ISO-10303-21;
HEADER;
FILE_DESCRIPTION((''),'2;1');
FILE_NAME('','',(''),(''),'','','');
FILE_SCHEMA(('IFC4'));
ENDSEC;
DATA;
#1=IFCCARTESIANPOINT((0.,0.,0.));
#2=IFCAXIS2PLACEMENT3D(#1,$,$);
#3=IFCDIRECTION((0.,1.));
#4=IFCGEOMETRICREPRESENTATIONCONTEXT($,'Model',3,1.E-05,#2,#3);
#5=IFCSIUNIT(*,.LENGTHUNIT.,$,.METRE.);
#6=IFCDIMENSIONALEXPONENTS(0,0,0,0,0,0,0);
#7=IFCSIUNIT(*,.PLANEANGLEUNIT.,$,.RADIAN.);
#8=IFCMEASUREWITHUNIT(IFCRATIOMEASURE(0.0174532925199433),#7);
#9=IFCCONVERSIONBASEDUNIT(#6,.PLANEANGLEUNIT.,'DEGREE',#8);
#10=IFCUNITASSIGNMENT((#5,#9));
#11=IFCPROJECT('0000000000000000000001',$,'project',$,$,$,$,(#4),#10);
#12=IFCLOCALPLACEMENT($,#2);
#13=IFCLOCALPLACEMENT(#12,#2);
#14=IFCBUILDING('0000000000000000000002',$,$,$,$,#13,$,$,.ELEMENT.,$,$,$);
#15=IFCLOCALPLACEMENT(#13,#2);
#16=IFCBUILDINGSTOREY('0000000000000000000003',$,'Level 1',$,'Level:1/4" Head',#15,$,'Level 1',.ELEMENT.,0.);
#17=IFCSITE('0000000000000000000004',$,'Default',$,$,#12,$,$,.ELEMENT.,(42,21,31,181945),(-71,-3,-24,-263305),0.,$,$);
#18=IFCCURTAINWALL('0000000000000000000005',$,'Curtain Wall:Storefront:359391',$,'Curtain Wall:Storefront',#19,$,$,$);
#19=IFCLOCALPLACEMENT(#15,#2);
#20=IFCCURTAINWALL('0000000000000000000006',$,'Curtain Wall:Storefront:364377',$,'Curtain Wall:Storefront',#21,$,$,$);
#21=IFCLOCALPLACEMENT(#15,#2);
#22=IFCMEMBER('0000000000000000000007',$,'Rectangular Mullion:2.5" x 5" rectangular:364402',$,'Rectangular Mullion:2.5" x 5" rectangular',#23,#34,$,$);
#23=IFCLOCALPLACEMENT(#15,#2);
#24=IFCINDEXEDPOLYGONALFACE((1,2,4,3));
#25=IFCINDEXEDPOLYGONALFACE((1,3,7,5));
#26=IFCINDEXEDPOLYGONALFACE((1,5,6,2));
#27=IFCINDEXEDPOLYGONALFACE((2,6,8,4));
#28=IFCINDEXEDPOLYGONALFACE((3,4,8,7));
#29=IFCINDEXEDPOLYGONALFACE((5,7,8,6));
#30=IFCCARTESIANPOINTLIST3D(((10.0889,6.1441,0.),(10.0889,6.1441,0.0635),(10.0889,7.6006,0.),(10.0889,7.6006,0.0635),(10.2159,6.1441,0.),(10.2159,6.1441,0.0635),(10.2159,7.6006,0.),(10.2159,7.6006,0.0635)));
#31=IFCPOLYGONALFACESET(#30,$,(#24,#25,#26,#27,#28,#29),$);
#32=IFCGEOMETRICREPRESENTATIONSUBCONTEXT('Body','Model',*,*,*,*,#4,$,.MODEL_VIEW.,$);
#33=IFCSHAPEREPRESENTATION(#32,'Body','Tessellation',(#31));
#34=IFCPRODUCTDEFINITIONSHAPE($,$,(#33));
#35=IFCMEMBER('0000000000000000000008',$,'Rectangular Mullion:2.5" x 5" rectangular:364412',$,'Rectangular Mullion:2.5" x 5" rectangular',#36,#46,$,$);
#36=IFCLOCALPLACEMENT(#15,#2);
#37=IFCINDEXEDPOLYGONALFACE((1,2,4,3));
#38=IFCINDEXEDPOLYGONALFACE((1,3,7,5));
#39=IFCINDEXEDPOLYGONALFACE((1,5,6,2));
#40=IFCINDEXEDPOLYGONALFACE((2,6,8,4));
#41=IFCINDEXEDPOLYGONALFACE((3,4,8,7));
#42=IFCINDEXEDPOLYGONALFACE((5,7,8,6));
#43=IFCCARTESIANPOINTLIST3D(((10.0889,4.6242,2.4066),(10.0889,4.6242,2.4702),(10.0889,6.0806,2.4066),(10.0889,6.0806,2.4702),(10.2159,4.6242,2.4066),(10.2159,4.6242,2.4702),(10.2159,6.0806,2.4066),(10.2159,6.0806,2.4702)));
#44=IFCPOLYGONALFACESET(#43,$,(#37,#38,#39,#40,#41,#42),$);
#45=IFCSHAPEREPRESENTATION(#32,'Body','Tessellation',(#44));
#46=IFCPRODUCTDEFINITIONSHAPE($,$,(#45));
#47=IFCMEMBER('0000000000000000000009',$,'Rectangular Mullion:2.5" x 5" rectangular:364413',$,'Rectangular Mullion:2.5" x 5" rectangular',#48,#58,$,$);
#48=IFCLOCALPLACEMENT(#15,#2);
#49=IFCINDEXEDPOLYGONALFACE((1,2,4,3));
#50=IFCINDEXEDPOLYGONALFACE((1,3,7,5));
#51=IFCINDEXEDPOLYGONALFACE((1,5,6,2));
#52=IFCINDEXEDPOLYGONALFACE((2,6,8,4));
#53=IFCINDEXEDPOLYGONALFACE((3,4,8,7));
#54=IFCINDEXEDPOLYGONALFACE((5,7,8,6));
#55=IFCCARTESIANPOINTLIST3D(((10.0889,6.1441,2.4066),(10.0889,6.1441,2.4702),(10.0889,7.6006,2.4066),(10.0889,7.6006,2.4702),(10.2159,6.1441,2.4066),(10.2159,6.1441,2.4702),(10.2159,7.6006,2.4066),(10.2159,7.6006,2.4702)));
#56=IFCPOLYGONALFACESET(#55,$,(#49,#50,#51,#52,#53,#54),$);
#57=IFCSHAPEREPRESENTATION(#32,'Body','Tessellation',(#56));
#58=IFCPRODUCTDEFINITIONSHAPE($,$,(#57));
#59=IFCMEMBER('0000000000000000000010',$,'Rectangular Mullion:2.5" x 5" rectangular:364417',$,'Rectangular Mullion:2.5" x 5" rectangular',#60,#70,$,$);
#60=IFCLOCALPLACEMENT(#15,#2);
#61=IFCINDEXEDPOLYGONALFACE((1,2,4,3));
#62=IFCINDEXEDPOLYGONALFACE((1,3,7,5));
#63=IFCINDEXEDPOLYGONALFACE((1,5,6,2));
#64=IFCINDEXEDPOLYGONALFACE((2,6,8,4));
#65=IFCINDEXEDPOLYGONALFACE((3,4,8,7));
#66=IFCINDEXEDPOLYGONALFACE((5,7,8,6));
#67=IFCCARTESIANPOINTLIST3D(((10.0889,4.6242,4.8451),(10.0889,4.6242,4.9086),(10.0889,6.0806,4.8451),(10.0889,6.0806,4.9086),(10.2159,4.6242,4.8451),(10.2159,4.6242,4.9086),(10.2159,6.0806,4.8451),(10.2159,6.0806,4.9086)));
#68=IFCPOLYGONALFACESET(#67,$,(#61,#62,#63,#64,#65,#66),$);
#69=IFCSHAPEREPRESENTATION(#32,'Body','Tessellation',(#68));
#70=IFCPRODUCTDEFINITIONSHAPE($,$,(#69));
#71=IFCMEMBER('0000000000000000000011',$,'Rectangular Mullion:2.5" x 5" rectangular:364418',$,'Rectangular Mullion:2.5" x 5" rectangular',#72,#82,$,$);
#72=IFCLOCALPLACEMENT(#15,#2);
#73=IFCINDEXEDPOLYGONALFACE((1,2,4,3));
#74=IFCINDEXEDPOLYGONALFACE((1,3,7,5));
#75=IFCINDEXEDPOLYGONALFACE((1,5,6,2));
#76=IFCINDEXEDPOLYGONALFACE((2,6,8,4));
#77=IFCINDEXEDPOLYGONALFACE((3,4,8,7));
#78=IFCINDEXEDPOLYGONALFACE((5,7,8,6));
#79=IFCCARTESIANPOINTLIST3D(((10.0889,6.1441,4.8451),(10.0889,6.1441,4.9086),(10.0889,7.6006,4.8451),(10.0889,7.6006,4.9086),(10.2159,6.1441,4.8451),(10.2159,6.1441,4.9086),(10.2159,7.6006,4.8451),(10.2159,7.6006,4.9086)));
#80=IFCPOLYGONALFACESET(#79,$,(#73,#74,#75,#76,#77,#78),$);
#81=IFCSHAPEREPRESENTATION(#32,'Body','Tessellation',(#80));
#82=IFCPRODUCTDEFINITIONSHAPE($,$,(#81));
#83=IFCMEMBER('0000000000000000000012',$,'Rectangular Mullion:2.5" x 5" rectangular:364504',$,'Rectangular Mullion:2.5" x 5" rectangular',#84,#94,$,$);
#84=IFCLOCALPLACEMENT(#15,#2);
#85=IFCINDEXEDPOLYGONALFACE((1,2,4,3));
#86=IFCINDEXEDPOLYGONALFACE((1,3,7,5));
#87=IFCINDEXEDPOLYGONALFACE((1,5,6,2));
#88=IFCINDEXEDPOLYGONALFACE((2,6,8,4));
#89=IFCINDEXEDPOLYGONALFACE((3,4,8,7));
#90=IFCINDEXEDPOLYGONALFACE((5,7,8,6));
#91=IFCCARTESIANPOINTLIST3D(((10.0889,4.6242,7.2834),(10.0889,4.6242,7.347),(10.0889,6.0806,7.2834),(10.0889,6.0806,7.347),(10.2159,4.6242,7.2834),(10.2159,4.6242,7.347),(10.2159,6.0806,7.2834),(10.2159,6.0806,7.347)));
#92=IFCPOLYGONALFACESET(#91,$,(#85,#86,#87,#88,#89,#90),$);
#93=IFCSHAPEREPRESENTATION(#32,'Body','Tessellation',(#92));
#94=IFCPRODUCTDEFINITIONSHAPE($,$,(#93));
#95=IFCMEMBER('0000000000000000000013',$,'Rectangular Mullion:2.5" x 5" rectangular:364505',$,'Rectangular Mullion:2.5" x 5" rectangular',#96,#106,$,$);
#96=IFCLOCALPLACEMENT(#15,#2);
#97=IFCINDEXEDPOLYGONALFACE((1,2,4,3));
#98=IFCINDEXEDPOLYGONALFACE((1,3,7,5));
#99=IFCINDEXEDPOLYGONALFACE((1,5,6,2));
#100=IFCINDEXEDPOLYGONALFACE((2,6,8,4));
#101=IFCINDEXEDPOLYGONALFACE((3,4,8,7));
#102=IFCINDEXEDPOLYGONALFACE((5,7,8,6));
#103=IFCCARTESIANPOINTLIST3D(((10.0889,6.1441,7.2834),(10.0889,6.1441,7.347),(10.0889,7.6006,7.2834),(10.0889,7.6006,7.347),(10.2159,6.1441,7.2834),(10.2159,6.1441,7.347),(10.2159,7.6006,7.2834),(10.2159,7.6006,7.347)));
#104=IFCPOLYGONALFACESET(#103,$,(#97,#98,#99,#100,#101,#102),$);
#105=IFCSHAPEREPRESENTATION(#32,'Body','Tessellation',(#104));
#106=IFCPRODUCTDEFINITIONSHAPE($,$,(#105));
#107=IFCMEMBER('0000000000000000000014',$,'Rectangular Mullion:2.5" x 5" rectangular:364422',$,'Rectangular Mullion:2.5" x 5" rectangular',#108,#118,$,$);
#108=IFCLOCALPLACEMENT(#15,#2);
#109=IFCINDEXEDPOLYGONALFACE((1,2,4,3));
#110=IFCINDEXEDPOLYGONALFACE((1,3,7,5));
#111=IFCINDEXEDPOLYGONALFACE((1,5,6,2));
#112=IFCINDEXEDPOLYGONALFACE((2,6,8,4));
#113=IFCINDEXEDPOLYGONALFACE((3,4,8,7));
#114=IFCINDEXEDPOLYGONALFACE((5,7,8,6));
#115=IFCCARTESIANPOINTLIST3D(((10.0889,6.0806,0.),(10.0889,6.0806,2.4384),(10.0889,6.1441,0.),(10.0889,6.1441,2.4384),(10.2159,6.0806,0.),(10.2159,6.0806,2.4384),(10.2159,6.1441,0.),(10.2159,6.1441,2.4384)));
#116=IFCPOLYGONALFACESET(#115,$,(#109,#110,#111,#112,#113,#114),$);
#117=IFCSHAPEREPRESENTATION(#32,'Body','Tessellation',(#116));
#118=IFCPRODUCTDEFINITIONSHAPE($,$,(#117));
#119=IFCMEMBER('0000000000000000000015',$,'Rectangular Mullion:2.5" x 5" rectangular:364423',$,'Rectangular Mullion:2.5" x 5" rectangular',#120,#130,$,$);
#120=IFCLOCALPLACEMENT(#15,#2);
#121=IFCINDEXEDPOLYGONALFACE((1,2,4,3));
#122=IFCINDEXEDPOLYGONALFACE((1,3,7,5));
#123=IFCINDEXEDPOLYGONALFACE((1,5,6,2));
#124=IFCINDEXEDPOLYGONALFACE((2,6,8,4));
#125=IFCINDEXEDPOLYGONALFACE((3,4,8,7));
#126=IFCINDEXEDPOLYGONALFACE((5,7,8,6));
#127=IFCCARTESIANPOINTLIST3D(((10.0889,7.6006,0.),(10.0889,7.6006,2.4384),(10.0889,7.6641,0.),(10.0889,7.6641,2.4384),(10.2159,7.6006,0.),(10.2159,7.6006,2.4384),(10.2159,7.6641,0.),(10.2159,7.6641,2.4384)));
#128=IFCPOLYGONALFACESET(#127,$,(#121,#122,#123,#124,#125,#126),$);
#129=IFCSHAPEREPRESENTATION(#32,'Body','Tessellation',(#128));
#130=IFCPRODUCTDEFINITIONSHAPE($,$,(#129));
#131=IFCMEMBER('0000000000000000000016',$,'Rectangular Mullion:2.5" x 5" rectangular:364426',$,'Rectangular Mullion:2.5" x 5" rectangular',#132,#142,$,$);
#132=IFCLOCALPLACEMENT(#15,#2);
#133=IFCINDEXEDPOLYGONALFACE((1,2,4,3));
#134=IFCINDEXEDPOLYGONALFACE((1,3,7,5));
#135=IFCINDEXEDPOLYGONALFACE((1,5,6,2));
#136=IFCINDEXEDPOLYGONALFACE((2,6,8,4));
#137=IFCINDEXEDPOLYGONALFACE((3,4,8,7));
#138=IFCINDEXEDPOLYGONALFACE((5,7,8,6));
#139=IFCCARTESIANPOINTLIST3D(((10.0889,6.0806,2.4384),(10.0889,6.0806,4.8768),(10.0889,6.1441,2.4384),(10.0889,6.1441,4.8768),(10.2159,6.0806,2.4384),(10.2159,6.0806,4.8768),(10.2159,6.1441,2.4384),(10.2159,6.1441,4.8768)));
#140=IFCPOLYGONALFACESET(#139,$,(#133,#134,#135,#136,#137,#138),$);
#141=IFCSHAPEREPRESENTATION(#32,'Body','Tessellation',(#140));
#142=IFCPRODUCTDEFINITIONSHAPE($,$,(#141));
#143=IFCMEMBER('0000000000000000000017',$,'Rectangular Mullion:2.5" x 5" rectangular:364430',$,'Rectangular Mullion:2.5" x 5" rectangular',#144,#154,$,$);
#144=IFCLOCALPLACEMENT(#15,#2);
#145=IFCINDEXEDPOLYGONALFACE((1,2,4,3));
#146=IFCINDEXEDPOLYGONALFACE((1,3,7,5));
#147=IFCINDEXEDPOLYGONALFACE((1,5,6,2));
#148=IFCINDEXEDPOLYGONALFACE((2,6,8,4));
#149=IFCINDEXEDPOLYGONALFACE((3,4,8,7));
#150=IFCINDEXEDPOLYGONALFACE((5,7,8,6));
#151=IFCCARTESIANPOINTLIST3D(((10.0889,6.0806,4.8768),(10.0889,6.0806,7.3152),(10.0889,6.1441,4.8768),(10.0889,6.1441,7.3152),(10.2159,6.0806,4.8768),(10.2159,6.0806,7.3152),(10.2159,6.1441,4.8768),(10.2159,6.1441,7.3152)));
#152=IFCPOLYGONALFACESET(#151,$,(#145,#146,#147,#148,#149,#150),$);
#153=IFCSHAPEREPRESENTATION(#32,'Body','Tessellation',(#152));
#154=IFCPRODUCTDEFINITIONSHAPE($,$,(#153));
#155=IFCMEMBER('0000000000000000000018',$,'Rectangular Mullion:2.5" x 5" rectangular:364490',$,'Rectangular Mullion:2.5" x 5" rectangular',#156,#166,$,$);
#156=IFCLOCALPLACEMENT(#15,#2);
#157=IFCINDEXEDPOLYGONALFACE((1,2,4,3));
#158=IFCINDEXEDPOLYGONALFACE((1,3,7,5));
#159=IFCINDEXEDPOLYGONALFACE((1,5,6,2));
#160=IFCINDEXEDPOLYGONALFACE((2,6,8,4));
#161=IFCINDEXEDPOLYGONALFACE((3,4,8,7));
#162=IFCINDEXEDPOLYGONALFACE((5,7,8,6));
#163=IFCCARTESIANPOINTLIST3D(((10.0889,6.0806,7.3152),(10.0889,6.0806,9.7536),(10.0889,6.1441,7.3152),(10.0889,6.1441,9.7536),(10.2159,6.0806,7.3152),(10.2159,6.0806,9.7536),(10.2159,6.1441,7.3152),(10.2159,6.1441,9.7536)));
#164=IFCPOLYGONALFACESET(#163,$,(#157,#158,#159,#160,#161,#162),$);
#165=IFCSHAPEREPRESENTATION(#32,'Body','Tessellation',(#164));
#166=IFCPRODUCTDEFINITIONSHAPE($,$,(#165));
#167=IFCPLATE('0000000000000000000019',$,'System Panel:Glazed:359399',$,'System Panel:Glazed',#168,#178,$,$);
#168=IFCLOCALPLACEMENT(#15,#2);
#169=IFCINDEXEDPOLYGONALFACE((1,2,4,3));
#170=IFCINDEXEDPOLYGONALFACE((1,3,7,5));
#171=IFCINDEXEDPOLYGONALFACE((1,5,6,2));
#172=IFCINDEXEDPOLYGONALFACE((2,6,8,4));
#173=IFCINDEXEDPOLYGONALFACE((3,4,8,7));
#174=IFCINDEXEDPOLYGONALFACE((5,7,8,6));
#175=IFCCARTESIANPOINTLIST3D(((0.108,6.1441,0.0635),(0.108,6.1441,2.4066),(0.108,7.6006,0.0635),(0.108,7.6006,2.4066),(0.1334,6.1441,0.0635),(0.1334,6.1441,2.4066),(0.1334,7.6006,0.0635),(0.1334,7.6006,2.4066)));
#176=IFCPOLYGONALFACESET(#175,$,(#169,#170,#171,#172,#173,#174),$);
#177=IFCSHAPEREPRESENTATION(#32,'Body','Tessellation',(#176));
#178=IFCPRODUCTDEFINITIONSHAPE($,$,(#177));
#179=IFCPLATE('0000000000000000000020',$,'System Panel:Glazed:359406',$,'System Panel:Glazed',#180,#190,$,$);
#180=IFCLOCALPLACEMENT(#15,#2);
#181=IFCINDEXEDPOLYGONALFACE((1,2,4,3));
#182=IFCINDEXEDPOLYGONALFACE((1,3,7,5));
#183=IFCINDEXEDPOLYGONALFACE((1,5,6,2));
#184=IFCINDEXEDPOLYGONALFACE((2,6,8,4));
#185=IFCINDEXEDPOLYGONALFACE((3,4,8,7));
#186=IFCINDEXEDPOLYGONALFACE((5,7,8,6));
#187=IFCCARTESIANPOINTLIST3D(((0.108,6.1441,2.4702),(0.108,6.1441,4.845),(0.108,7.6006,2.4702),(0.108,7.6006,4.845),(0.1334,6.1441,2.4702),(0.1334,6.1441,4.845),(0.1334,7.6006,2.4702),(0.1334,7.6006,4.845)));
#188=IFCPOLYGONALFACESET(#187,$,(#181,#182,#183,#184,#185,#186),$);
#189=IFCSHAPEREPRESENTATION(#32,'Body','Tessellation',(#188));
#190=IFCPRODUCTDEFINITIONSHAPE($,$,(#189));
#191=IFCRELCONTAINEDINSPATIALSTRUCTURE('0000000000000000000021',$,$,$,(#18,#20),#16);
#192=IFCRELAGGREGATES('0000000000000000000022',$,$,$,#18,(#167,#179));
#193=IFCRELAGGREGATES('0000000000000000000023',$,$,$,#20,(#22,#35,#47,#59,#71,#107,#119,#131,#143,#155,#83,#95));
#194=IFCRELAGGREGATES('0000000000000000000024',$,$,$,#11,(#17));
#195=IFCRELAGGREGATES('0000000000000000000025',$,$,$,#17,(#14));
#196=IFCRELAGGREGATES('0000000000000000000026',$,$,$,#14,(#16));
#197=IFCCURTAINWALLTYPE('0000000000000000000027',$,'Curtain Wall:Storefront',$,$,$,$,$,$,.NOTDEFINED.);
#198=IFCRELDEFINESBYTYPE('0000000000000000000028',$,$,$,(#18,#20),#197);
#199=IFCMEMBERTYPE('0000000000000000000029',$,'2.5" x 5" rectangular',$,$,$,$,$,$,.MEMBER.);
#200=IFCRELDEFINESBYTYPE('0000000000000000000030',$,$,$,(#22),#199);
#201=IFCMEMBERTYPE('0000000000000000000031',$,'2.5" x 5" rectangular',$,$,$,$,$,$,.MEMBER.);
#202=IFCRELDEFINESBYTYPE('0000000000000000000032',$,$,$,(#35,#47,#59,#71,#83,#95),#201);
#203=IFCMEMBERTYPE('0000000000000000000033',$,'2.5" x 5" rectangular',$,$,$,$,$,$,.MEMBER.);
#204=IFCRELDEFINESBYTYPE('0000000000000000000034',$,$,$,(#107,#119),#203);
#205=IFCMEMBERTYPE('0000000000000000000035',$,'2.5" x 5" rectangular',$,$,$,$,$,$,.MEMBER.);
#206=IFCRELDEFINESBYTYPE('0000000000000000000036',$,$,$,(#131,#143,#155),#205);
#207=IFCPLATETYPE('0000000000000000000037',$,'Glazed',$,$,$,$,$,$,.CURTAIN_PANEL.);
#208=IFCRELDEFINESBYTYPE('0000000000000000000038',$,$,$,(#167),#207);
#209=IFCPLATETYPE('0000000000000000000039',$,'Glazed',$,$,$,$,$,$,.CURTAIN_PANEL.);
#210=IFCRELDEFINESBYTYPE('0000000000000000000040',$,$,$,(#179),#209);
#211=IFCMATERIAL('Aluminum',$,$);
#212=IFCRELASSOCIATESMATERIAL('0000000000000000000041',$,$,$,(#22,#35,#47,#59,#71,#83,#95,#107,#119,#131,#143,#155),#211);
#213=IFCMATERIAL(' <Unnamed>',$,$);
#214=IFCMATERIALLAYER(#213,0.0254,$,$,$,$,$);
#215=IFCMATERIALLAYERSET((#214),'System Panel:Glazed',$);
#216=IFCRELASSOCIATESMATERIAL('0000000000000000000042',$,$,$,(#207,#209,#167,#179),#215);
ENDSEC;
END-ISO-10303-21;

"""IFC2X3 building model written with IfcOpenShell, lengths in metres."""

from ifc_helpers import new_model, entity, si_unit, converted_unit, direction, frame, frame_2d, origin, origin_2d_with_axis, place, context, subcontext, project, spatial, rectangle, extrude, source, transform, mapped, material, layer, layer_set, layer_usage, type_object, type_shapes, element, aggregate, save


model = new_model("IFC2X3")

# Units and contexts
model_context = context("Model", 3, precision=1e-05, world=origin(), true_north=direction((0.0, 1.0)))
body_context = subcontext(model_context, "Body", "Model", "MODEL_VIEW")
ifc_project = project(units=[si_unit("LENGTHUNIT", "METRE"), converted_unit("PLANEANGLEUNIT", "DEGREE", entity("IfcRatioMeasure", 0.0174532925199433), si_unit("PLANEANGLEUNIT", "RADIAN"), dimensions=[0, 0, 0, 0, 0, 0, 0])], contexts=[model_context])

# Site, building, storey
site_placement = place(None, origin())
site = spatial("IfcSite", under=ifc_project, at=site_placement, Name="Default", CompositionType="ELEMENT", RefLatitude=(42, 21, 31, 181945), RefLongitude=(-71, -3, -24, -263305), RefElevation=0.0)
building_placement = place(site_placement, origin())
building = spatial("IfcBuilding", under=site, at=building_placement, CompositionType="ELEMENT")
storey_placement = place(building_placement, origin())
storey = spatial("IfcBuildingStorey", under=building, at=storey_placement, Name="Level 1", ObjectType="Level:1/4\" Head", LongName="Level 1", CompositionType="ELEMENT", Elevation=0.0)

# Curtain walls, members
curtain_wall_type = type_object("IfcCurtainWallType", Name="Curtain Wall:Storefront", PredefinedType="NOTDEFINED")
curtain_wall_1_placement = place(storey_placement, origin())
curtain_wall_1 = element("IfcCurtainWall", 1, at=curtain_wall_1_placement, inside=storey, type_object=curtain_wall_type, Name="Curtain Wall:Storefront:359391", ObjectType="Curtain Wall:Storefront")
ifc_material_1 = material(Name="Aluminum")
curtain_wall_2_placement = place(storey_placement, origin())
curtain_wall_2 = element("IfcCurtainWall", 2, at=curtain_wall_2_placement, inside=storey, type_object=curtain_wall_type, Name="Curtain Wall:Storefront:364377", ObjectType="Curtain Wall:Storefront")
member_type_1 = type_object("IfcMemberType", Name="2.5\" x 5\" rectangular", PredefinedType="MEMBER")
shared_shape_1 = source(origin(), body_context, "Body", "SweptSolid", [
    extrude(rectangle(XDim=0.127, YDim=0.0635, at=origin_2d_with_axis()), frame((-0.0318, 0.0, -1.4565), z_axis=(0.0, 0.0, 1.0), x_axis=(0.0, -1.0, 0.0)), (0.0, 0.0, 1.0), 1.4565),
])
type_shapes(member_type_1, [shared_shape_1])
member_1_placement = place(storey_placement, frame((10.1524, 6.1441, 0.0), z_axis=(0.0, -1.0, 0.0), x_axis=(0.0, 0.0, -1.0)))
member_1 = element("IfcMember", 3, at=member_1_placement, type_object=member_type_1, material=ifc_material_1, Name="Rectangular Mullion:2.5\" x 5\" rectangular:364402", ObjectType="Rectangular Mullion:2.5\" x 5\" rectangular", context=body_context, shape_type="MappedRepresentation", body=[
    mapped(shared_shape_1, transform((0.0, 0.0, 0.0), scale=1.0)),
])
member_type_2 = type_object("IfcMemberType", Name="2.5\" x 5\" rectangular", PredefinedType="MEMBER")
shared_shape_2 = source(origin(), body_context, "Body", "SweptSolid", [
    extrude(rectangle(XDim=0.127, YDim=0.0635, at=origin_2d_with_axis()), frame((0.0, 0.0, -1.4565), z_axis=(0.0, 0.0, 1.0), x_axis=(0.0, -1.0, 0.0)), (0.0, 0.0, 1.0), 1.4565),
])
type_shapes(member_type_2, [shared_shape_2])
member_2_placement = place(storey_placement, frame((10.1524, 6.0806, 2.4384), z_axis=(0.0, 1.0, 0.0), x_axis=(0.0, 0.0, 1.0)))
member_2 = element("IfcMember", 4, at=member_2_placement, type_object=member_type_2, material=ifc_material_1, Name="Rectangular Mullion:2.5\" x 5\" rectangular:364412", ObjectType="Rectangular Mullion:2.5\" x 5\" rectangular", context=body_context, shape_type="MappedRepresentation", body=[
    mapped(shared_shape_2, transform((0.0, 0.0, 0.0), scale=1.0)),
])
member_3_placement = place(storey_placement, frame((10.1524, 7.6006, 2.4384), z_axis=(0.0, 1.0, 0.0), x_axis=(0.0, 0.0, 1.0)))
member_3 = element("IfcMember", 5, at=member_3_placement, type_object=member_type_2, material=ifc_material_1, Name="Rectangular Mullion:2.5\" x 5\" rectangular:364413", ObjectType="Rectangular Mullion:2.5\" x 5\" rectangular", context=body_context, shape_type="MappedRepresentation", body=[
    mapped(shared_shape_2, transform((0.0, 0.0, 0.0), scale=1.0)),
])
member_4_placement = place(storey_placement, frame((10.1524, 6.0806, 4.8768), z_axis=(0.0, 1.0, 0.0), x_axis=(0.0, 0.0, 1.0)))
member_4 = element("IfcMember", 6, at=member_4_placement, type_object=member_type_2, material=ifc_material_1, Name="Rectangular Mullion:2.5\" x 5\" rectangular:364417", ObjectType="Rectangular Mullion:2.5\" x 5\" rectangular", context=body_context, shape_type="MappedRepresentation", body=[
    mapped(shared_shape_2, transform((0.0, 0.0, 0.0), scale=1.0)),
])
member_5_placement = place(storey_placement, frame((10.1524, 7.6006, 4.8768), z_axis=(0.0, 1.0, 0.0), x_axis=(0.0, 0.0, 1.0)))
member_5 = element("IfcMember", 7, at=member_5_placement, type_object=member_type_2, material=ifc_material_1, Name="Rectangular Mullion:2.5\" x 5\" rectangular:364418", ObjectType="Rectangular Mullion:2.5\" x 5\" rectangular", context=body_context, shape_type="MappedRepresentation", body=[
    mapped(shared_shape_2, transform((0.0, 0.0, 0.0), scale=1.0)),
])
member_6_placement = place(storey_placement, frame((10.1524, 6.0806, 7.3152), z_axis=(0.0, 1.0, 0.0), x_axis=(0.0, 0.0, 1.0)))
member_6 = element("IfcMember", 8, at=member_6_placement, type_object=member_type_2, material=ifc_material_1, Name="Rectangular Mullion:2.5\" x 5\" rectangular:364504", ObjectType="Rectangular Mullion:2.5\" x 5\" rectangular", context=body_context, shape_type="MappedRepresentation", body=[
    mapped(shared_shape_2, transform((0.0, 0.0, 0.0), scale=1.0)),
])
member_7_placement = place(storey_placement, frame((10.1524, 7.6006, 7.3152), z_axis=(0.0, 1.0, 0.0), x_axis=(0.0, 0.0, 1.0)))
member_7 = element("IfcMember", 9, at=member_7_placement, type_object=member_type_2, material=ifc_material_1, Name="Rectangular Mullion:2.5\" x 5\" rectangular:364505", ObjectType="Rectangular Mullion:2.5\" x 5\" rectangular", context=body_context, shape_type="MappedRepresentation", body=[
    mapped(shared_shape_2, transform((0.0, 0.0, 0.0), scale=1.0)),
])
member_type_3 = type_object("IfcMemberType", Name="2.5\" x 5\" rectangular", PredefinedType="MEMBER")
shared_shape_3 = source(origin(), body_context, "Body", "SweptSolid", [
    extrude(rectangle(XDim=0.127, YDim=0.0635, at=origin_2d_with_axis()), frame((0.0, 0.0, -2.4384), z_axis=(0.0, 0.0, 1.0), x_axis=(0.0, -1.0, 0.0)), (0.0, 0.0, 1.0), 2.4384),
])
type_shapes(member_type_3, [shared_shape_3])
member_8_placement = place(storey_placement, frame((10.1524, 6.1124, 0.0), z_axis=(0.0, 0.0, -1.0), x_axis=(0.0, 1.0, 0.0)))
member_8 = element("IfcMember", 10, at=member_8_placement, type_object=member_type_3, material=ifc_material_1, Name="Rectangular Mullion:2.5\" x 5\" rectangular:364422", ObjectType="Rectangular Mullion:2.5\" x 5\" rectangular", context=body_context, shape_type="MappedRepresentation", body=[
    mapped(shared_shape_3, transform((0.0, 0.0, 0.0), scale=1.0)),
])
member_9_placement = place(storey_placement, frame((10.1524, 7.6324, 0.0), z_axis=(0.0, 0.0, -1.0), x_axis=(0.0, 1.0, 0.0)))
member_9 = element("IfcMember", 11, at=member_9_placement, type_object=member_type_3, material=ifc_material_1, Name="Rectangular Mullion:2.5\" x 5\" rectangular:364423", ObjectType="Rectangular Mullion:2.5\" x 5\" rectangular", context=body_context, shape_type="MappedRepresentation", body=[
    mapped(shared_shape_3, transform((0.0, 0.0, 0.0), scale=1.0)),
])
member_type_4 = type_object("IfcMemberType", Name="2.5\" x 5\" rectangular", PredefinedType="MEMBER")
shared_shape_4 = source(origin(), body_context, "Body", "SweptSolid", [
    extrude(rectangle(XDim=0.127, YDim=0.0635, at=origin_2d_with_axis()), frame((0.0, 0.0, -2.4384), z_axis=(0.0, 0.0, 1.0), x_axis=(0.0, -1.0, 0.0)), (0.0, 0.0, 1.0), 2.4384),
])
type_shapes(member_type_4, [shared_shape_4])
member_10_placement = place(storey_placement, frame((10.1524, 6.1124, 2.4384), z_axis=(0.0, 0.0, -1.0), x_axis=(0.0, 1.0, 0.0)))
member_10 = element("IfcMember", 12, at=member_10_placement, type_object=member_type_4, material=ifc_material_1, Name="Rectangular Mullion:2.5\" x 5\" rectangular:364426", ObjectType="Rectangular Mullion:2.5\" x 5\" rectangular", context=body_context, shape_type="MappedRepresentation", body=[
    mapped(shared_shape_4, transform((0.0, 0.0, 0.0), scale=1.0)),
])
member_11_placement = place(storey_placement, frame((10.1524, 6.1124, 4.8768), z_axis=(0.0, 0.0, -1.0), x_axis=(0.0, 1.0, 0.0)))
member_11 = element("IfcMember", 13, at=member_11_placement, type_object=member_type_4, material=ifc_material_1, Name="Rectangular Mullion:2.5\" x 5\" rectangular:364430", ObjectType="Rectangular Mullion:2.5\" x 5\" rectangular", context=body_context, shape_type="MappedRepresentation", body=[
    mapped(shared_shape_4, transform((0.0, 0.0, 0.0), scale=1.0)),
])
member_12_placement = place(storey_placement, frame((10.1524, 6.1124, 7.3152), z_axis=(0.0, 0.0, -1.0), x_axis=(0.0, 1.0, 0.0)))
member_12 = element("IfcMember", 14, at=member_12_placement, type_object=member_type_4, material=ifc_material_1, Name="Rectangular Mullion:2.5\" x 5\" rectangular:364490", ObjectType="Rectangular Mullion:2.5\" x 5\" rectangular", context=body_context, shape_type="MappedRepresentation", body=[
    mapped(shared_shape_4, transform((0.0, 0.0, 0.0), scale=1.0)),
])

# Plates
ifc_material_2 = material(Name=" <Unnamed>")
ifc_layer = layer(ifc_material_2, 0.0254)
ifc_layer_set = layer_set([ifc_layer], Name="System Panel:Glazed")
ifc_layer_usage_1 = layer_usage(ifc_layer_set, "AXIS3", "POSITIVE", 0.1042)
plate_type_1 = type_object("IfcPlateType", Name="Glazed", PredefinedType="CURTAIN_PANEL", material=ifc_layer_set)
shared_shape_5 = source(origin(), body_context, "Body", "SweptSolid", [
    extrude(rectangle(XDim=0.0254, YDim=1.4565, at=frame_2d((0.0, 0.0), x_axis=(1.0, 0.0))), frame((0.7282, 0.0127, 0.0), z_axis=(0.0, 0.0, 1.0), x_axis=(0.0, 1.0, 0.0)), (0.0, 0.0, 1.0), 2.3432),
])
type_shapes(plate_type_1, [shared_shape_5])
plate_1_placement = place(curtain_wall_1_placement, frame((0.1334, 6.1441, 0.0635), z_axis=(0.0, 0.0, 1.0), x_axis=(0.0, 1.0, 0.0)))
plate_1 = element("IfcPlate", 15, at=plate_1_placement, type_object=plate_type_1, material=ifc_layer_usage_1, Name="System Panel:Glazed:359399", ObjectType="System Panel:Glazed", context=body_context, shape_type="MappedRepresentation", body=[
    mapped(shared_shape_5, transform((0.0, 0.0, 0.0), scale=1.0)),
])
ifc_layer_usage_2 = layer_usage(ifc_layer_set, "AXIS3", "POSITIVE", 0.1042)
plate_type_2 = type_object("IfcPlateType", Name="Glazed", PredefinedType="CURTAIN_PANEL", material=ifc_layer_set)
shared_shape_6 = source(origin(), body_context, "Body", "SweptSolid", [
    extrude(rectangle(XDim=0.0254, YDim=1.4565, at=frame_2d((0.0, 0.0), x_axis=(1.0, 0.0))), frame((0.7282, 0.0127, 0.0), z_axis=(0.0, 0.0, 1.0), x_axis=(0.0, 1.0, 0.0)), (0.0, 0.0, 1.0), 2.3749),
])
type_shapes(plate_type_2, [shared_shape_6])
plate_2_placement = place(curtain_wall_1_placement, frame((0.1334, 6.1441, 2.4701), z_axis=(0.0, 0.0, 1.0), x_axis=(0.0, 1.0, 0.0)))
plate_2 = element("IfcPlate", 16, at=plate_2_placement, type_object=plate_type_2, material=ifc_layer_usage_2, Name="System Panel:Glazed:359406", ObjectType="System Panel:Glazed", context=body_context, shape_type="MappedRepresentation", body=[
    mapped(shared_shape_6, transform((0.0, 0.0, 0.0), scale=1.0)),
])
aggregate(curtain_wall_1, [plate_1, plate_2])
aggregate(curtain_wall_2, [member_1, member_2, member_3, member_4, member_5, member_8, member_9, member_10, member_11, member_12, member_6, member_7])

save(model, "model.ifc")
